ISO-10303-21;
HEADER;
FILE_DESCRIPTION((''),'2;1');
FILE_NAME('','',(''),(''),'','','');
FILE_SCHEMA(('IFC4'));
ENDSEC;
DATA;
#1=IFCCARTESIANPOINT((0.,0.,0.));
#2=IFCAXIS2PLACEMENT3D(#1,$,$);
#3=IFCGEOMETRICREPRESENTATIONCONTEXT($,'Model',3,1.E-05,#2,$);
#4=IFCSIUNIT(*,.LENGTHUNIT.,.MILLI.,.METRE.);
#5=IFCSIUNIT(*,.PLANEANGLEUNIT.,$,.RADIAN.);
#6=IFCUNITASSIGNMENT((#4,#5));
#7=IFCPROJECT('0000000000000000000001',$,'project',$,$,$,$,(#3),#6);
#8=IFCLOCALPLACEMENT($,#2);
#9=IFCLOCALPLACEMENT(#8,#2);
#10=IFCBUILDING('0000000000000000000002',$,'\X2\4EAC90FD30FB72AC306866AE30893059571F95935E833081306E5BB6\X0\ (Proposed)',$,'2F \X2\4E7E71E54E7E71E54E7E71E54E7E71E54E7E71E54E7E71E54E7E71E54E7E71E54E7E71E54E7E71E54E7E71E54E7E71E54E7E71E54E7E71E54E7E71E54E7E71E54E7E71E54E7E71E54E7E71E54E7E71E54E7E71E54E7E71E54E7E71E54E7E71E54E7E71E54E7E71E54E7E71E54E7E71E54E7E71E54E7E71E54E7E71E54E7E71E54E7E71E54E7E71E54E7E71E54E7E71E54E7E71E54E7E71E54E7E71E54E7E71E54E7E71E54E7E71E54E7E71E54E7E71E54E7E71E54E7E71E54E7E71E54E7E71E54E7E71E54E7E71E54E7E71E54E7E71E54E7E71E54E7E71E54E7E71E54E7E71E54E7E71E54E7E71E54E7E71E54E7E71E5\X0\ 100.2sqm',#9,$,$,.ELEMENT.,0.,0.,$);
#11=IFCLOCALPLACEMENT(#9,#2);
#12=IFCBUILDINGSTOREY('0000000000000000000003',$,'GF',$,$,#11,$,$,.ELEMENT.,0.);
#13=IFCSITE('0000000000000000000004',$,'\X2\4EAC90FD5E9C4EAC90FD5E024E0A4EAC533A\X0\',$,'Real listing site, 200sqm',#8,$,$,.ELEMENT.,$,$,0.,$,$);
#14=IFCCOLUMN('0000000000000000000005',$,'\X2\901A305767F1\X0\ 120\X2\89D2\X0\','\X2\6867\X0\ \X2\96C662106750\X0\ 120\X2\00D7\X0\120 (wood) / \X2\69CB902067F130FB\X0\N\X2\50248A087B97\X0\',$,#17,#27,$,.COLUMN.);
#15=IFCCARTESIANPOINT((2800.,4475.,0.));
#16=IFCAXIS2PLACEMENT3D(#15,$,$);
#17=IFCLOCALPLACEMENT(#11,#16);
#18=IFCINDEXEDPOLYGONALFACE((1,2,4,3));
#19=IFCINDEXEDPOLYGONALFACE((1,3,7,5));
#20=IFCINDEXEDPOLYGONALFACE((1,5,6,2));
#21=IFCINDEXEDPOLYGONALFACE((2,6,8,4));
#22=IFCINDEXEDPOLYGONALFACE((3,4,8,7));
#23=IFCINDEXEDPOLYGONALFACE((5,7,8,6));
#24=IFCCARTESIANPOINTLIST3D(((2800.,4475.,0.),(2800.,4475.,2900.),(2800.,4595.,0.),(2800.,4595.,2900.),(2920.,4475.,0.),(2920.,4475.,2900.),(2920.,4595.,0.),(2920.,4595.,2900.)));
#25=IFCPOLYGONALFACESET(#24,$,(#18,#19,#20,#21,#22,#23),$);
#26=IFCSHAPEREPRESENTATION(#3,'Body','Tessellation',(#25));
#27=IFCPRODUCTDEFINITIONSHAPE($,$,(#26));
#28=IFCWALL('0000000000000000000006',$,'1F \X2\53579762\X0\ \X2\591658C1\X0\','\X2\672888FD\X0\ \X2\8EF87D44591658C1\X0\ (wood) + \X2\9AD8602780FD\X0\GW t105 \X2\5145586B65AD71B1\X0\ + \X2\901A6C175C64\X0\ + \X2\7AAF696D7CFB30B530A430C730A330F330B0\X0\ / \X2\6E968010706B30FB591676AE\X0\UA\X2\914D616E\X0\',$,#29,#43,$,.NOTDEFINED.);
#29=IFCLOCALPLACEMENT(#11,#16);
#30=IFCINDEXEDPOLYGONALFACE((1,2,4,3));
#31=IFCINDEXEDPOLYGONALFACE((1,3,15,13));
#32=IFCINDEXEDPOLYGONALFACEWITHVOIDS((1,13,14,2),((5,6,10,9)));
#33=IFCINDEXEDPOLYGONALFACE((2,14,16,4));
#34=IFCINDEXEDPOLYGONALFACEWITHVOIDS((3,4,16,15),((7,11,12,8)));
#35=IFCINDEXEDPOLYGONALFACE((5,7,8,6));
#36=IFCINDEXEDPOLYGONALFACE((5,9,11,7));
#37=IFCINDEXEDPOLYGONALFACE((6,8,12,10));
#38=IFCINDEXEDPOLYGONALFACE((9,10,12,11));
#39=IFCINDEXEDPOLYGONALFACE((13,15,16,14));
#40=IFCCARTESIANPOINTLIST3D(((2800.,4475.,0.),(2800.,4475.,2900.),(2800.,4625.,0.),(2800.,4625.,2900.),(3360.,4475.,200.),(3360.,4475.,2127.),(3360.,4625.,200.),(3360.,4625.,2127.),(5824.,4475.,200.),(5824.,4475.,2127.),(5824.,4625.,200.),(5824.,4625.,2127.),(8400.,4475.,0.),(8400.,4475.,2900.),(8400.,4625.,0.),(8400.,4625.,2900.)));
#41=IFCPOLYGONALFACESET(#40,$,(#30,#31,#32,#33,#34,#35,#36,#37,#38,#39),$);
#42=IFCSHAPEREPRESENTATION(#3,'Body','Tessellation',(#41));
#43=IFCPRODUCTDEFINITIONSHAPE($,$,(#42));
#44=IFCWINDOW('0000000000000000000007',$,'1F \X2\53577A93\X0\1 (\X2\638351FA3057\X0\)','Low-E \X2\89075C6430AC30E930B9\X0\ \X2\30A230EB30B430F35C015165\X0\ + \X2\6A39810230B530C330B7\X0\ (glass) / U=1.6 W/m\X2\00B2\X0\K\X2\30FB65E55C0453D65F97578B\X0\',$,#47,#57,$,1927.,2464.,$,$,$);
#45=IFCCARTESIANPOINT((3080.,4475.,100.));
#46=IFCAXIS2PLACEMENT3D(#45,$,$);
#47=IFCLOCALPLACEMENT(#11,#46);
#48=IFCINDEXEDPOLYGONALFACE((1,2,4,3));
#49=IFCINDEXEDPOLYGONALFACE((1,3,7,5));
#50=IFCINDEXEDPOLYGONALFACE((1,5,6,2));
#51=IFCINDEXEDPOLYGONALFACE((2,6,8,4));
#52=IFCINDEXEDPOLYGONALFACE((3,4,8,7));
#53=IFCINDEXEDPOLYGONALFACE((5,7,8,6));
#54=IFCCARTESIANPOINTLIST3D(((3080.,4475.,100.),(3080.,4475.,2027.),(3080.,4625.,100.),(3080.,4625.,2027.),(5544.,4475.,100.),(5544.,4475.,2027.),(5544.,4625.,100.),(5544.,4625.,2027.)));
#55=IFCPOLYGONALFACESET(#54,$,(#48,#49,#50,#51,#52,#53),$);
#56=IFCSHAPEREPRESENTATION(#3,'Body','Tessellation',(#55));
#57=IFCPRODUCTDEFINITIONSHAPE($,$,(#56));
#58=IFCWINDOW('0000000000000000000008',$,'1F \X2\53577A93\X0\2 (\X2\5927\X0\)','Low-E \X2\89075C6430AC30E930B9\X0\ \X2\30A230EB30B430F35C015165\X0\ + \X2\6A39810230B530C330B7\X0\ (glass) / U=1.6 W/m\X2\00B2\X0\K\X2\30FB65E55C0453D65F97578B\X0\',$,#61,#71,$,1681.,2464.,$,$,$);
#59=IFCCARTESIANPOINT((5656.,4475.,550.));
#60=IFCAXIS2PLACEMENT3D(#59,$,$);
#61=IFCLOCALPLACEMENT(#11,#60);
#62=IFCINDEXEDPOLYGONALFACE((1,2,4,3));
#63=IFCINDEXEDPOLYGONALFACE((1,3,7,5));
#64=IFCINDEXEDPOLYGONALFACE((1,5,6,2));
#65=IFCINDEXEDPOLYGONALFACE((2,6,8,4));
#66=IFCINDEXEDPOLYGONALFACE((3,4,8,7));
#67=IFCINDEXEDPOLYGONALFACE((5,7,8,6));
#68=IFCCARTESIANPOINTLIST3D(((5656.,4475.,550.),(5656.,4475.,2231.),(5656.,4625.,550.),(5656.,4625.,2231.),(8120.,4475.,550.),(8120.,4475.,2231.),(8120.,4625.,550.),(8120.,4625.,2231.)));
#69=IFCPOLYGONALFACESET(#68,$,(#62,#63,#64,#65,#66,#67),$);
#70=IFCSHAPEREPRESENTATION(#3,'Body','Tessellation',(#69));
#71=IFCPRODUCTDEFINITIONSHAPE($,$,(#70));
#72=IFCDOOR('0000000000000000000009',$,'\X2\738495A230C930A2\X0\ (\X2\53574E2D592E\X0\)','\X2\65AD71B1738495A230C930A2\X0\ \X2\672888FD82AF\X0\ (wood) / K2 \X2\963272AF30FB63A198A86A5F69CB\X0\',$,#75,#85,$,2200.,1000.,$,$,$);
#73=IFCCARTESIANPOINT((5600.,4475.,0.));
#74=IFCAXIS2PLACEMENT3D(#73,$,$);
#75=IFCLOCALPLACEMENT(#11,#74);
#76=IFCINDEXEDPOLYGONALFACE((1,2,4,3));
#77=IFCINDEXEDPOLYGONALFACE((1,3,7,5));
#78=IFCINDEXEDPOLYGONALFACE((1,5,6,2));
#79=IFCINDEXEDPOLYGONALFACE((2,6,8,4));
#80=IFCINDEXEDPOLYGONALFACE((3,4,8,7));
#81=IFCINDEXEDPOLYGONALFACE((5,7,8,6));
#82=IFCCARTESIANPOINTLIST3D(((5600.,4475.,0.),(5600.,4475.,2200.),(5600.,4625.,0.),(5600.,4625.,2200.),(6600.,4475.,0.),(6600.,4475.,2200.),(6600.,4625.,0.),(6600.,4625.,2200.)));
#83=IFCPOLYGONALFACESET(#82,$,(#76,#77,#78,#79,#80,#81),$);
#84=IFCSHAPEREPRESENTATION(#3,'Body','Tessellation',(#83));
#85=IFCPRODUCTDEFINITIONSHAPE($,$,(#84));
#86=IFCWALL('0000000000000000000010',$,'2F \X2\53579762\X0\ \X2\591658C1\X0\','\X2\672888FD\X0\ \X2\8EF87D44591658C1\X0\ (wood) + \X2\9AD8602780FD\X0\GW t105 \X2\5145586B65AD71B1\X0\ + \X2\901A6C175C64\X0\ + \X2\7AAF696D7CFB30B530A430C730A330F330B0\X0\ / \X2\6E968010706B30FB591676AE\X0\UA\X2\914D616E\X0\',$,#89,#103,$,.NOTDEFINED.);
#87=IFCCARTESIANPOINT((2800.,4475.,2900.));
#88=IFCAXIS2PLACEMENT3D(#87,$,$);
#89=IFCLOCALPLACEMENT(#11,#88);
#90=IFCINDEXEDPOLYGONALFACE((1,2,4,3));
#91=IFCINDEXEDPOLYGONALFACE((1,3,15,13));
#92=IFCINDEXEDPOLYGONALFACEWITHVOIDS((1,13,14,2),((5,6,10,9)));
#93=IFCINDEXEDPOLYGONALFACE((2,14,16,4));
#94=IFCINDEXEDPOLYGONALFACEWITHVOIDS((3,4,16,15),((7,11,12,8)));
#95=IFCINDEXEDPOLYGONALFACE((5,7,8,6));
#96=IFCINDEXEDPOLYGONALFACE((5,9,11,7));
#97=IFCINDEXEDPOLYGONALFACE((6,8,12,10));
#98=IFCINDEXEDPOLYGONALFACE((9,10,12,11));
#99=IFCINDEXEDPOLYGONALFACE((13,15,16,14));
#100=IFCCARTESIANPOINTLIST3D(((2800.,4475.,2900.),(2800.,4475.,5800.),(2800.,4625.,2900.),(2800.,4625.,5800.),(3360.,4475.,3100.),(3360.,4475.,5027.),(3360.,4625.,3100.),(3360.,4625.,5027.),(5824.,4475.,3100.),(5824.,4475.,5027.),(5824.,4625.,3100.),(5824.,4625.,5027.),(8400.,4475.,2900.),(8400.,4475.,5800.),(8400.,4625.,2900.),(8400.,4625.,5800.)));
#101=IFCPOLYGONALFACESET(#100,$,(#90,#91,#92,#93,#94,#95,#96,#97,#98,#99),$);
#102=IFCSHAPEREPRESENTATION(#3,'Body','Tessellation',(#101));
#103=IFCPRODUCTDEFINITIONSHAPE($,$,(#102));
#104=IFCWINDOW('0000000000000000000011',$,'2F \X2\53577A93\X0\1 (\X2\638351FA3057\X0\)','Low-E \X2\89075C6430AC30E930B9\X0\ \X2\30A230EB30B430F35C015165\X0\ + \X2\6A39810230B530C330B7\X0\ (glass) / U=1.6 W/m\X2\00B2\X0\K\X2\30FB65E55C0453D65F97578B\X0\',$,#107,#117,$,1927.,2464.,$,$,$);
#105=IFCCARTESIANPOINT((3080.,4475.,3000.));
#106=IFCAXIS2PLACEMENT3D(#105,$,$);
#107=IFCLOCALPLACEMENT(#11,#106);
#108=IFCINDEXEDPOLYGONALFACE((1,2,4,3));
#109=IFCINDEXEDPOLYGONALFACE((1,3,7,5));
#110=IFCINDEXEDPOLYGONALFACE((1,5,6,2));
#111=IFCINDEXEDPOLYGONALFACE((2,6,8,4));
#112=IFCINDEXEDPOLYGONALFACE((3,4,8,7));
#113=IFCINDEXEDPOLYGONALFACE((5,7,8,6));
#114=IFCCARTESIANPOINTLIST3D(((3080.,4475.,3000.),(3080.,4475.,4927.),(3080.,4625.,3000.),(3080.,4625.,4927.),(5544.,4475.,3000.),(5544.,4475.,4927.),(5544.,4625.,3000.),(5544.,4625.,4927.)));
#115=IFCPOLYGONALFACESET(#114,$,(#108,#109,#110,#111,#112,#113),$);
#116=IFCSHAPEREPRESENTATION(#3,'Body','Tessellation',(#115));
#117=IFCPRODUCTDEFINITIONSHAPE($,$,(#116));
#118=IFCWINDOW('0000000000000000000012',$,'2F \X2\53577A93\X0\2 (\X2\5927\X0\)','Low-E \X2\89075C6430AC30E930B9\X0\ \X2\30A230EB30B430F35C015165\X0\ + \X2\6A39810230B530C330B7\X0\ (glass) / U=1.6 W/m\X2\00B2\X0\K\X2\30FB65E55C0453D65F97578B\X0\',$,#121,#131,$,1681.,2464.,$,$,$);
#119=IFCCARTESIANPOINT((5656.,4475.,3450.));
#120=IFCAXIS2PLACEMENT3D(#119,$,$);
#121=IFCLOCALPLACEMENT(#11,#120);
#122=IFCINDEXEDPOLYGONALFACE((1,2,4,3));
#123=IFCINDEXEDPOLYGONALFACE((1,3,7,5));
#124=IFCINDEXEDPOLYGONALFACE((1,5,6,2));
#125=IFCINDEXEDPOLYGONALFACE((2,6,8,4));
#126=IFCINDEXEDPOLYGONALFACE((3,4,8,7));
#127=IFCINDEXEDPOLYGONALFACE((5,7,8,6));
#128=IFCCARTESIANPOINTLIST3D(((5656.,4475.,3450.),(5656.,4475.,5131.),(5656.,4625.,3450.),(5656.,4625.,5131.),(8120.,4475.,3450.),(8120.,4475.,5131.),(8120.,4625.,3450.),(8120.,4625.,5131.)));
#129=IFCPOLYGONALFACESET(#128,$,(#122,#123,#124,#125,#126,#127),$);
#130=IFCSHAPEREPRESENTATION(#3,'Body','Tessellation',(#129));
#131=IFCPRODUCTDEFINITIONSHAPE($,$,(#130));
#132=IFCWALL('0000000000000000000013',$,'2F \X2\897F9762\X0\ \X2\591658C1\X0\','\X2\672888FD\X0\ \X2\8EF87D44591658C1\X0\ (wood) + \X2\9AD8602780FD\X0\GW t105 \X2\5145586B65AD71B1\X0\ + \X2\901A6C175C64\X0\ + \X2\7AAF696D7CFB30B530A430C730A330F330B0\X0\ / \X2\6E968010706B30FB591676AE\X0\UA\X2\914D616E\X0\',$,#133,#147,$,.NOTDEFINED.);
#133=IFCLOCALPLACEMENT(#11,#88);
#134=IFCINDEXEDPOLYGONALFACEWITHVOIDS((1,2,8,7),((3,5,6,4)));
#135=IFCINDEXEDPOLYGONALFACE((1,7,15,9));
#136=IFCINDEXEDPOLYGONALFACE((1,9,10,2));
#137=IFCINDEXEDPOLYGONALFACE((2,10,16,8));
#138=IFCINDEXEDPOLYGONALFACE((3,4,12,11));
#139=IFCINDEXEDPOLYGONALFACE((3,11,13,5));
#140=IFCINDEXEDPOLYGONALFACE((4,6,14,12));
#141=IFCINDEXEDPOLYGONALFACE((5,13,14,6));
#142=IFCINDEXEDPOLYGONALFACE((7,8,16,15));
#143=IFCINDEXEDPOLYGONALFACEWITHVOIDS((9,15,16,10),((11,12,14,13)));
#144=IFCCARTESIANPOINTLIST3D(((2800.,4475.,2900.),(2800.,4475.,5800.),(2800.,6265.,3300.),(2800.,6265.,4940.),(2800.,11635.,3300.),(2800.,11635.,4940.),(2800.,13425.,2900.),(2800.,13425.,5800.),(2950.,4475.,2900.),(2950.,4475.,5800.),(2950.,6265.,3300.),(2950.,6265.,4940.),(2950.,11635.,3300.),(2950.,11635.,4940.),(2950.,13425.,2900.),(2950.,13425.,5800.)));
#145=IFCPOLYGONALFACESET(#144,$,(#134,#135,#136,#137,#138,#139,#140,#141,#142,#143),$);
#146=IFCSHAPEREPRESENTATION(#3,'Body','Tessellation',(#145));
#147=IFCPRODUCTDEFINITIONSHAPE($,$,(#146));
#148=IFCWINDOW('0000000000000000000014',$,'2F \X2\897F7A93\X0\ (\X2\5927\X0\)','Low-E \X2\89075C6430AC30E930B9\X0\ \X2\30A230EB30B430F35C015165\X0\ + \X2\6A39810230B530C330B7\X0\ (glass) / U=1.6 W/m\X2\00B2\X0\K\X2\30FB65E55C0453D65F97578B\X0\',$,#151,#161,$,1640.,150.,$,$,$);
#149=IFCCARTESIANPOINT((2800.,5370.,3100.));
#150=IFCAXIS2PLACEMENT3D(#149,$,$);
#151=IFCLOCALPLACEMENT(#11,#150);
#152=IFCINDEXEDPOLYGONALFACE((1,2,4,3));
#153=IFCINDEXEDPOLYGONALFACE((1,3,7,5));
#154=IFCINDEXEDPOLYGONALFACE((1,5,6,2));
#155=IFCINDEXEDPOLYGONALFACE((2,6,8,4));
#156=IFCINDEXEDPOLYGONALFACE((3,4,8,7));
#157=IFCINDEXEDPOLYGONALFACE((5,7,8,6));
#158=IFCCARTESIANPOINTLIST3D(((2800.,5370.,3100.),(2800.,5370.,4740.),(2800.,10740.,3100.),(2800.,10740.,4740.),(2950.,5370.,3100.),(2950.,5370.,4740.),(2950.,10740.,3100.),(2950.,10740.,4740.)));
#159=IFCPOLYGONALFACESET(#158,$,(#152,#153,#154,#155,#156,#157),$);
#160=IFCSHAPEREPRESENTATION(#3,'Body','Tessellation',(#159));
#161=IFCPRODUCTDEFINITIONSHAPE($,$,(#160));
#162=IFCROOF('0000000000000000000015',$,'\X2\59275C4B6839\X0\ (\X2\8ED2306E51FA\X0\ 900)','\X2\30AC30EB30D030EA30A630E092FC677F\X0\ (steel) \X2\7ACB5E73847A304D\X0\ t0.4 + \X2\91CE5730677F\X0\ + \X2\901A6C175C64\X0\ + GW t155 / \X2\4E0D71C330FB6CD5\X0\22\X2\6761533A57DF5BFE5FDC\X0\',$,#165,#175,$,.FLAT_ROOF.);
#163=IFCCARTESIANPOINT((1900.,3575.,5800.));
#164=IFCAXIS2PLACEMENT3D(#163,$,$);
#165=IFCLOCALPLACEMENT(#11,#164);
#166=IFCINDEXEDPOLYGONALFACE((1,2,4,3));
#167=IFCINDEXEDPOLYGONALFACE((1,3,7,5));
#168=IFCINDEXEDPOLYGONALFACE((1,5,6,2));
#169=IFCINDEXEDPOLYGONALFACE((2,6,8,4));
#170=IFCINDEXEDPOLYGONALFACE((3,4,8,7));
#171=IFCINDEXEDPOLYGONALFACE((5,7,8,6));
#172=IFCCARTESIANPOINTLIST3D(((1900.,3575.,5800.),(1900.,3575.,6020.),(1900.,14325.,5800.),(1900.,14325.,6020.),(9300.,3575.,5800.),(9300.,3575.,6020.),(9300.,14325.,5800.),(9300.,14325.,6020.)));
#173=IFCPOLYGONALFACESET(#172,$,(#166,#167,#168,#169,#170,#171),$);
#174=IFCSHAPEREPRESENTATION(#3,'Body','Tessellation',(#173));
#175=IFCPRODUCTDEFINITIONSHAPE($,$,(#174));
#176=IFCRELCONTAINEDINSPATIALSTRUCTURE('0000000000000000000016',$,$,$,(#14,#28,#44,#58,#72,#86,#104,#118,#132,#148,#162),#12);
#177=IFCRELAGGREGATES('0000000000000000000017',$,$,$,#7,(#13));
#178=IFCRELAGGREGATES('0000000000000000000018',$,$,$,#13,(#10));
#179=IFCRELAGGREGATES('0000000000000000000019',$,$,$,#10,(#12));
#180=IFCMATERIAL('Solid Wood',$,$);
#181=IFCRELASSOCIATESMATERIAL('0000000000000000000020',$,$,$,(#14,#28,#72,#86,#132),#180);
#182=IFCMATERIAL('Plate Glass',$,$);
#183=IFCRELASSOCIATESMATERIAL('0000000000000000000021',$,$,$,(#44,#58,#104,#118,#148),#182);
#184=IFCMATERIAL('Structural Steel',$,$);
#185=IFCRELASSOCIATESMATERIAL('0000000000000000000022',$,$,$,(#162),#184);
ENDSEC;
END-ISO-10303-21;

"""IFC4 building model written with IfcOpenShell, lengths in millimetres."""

from ifc_helpers import new_model, si_unit, frame, frame_2d, origin, place, context, project, spatial, rectangle, extrude, material, element, fill, save


model = new_model("IFC4")

# Units and contexts
model_context = context("Model", 3, precision=1e-05, world=origin())
ifc_project = project(units=[si_unit("LENGTHUNIT", "METRE", prefix="MILLI"), si_unit("PLANEANGLEUNIT", "RADIAN")], contexts=[model_context])

# Site, building, storey
site_placement = place(None, origin())
site = spatial("IfcSite", under=ifc_project, at=site_placement, Name="京都府京都市上京区", ObjectType="Real listing site, 200sqm", CompositionType="ELEMENT", RefElevation=0.0)
building_placement = place(site_placement, origin())
building = spatial("IfcBuilding", under=site, at=building_placement, Name="京都・犬と暮らす土間広めの家 (Proposed)", ObjectType="2F 乾燥乾燥乾燥乾燥乾燥乾燥乾燥乾燥乾燥乾燥乾燥乾燥乾燥乾燥乾燥乾燥乾燥乾燥乾燥乾燥乾燥乾燥乾燥乾燥乾燥乾燥乾燥乾燥乾燥乾燥乾燥乾燥乾燥乾燥乾燥乾燥乾燥乾燥乾燥乾燥乾燥乾燥乾燥乾燥乾燥乾燥乾燥乾燥乾燥乾燥乾燥乾燥乾燥乾燥乾燥乾燥乾燥乾燥乾燥乾燥 100.2sqm", CompositionType="ELEMENT", ElevationOfRefHeight=0.0, ElevationOfTerrain=0.0)
storey_placement = place(building_placement, origin())
storey = spatial("IfcBuildingStorey", under=building, at=storey_placement, Name="GF", CompositionType="ELEMENT", Elevation=0.0)

# Column
ifc_material_1 = material(Name="Solid Wood")
column_placement = place(storey_placement, frame((2800.0, 4475.0, 0.0)))
element("IfcColumn", 1, at=column_placement, inside=storey, material=ifc_material_1, Name="通し柱 120角", Description="桧 集成材 120×120 (wood) / 構造柱・N値計算", PredefinedType="COLUMN", context=model_context, shape_type="SweptSolid", body=[
    extrude(rectangle(XDim=120.0, YDim=120.0, at=frame_2d((60.0, 60.0))), frame((2800.0, 4475.0, 0.0)), (0.0, 0.0, 1.0), 2900.0),
])

# Wall, openings, windows, door
wall_1_placement = place(storey_placement, frame((2800.0, 4475.0, 0.0)))
wall_1 = element("IfcWall", 2, at=wall_1_placement, inside=storey, material=ifc_material_1, Name="1F 南面 外壁", Description="木製 軸組外壁 (wood) + 高性能GW t105 充填断熱 + 通気層 + 窯業系サイディング / 準耐火・外皮UA配慮", PredefinedType="NOTDEFINED", context=model_context, shape_type="SweptSolid", body=[
    extrude(rectangle(XDim=5600.0, YDim=150.0, at=frame_2d((2800.0, 75.0))), frame((2800.0, 4475.0, 0.0)), (0.0, 0.0, 1.0), 2900.0),
])
opening_1_placement = place(storey_placement, frame((3080.0, 4475.0, 100.0)))
opening_1 = element("IfcOpeningElement", 3, at=opening_1_placement, cuts=wall_1, PredefinedType="NOTDEFINED", context=model_context, shape_type="SweptSolid", body=[
    extrude(rectangle(XDim=2464.0, YDim=150.0, at=frame_2d((1232.0, 75.0))), frame((3080.0, 4475.0, 100.0)), (0.0, 0.0, 1.0), 1927.0),
])
opening_2_placement = place(storey_placement, frame((5656.0, 4475.0, 550.0)))
opening_2 = element("IfcOpeningElement", 4, at=opening_2_placement, cuts=wall_1, PredefinedType="NOTDEFINED", context=model_context, shape_type="SweptSolid", body=[
    extrude(rectangle(XDim=2464.0, YDim=150.0, at=frame_2d((1232.0, 75.0))), frame((5656.0, 4475.0, 550.0)), (0.0, 0.0, 1.0), 1681.0),
])
opening_3_placement = place(storey_placement, frame((5600.0, 4475.0, 0.0)))
opening_3 = element("IfcOpeningElement", 5, at=opening_3_placement, cuts=wall_1, PredefinedType="NOTDEFINED", context=model_context, shape_type="SweptSolid", body=[
    extrude(rectangle(XDim=1000.0, YDim=150.0, at=frame_2d((500.0, 75.0))), frame((5600.0, 4475.0, 0.0)), (0.0, 0.0, 1.0), 2200.0),
])
ifc_material_2 = material(Name="Plate Glass")
window_1_placement = place(storey_placement, frame((3080.0, 4475.0, 100.0)))
window_1 = element("IfcWindow", 6, at=window_1_placement, inside=storey, material=ifc_material_2, Name="1F 南窓1 (掃出し)", Description="Low-E 複層ガラス アルゴン封入 + 樹脂サッシ (glass) / U=1.6 W/m²K・日射取得型", OverallHeight=1927.0, OverallWidth=2464.0, context=model_context, shape_type="SweptSolid", body=[
    extrude(rectangle(XDim=2464.0, YDim=150.0, at=frame_2d((1232.0, 75.0))), frame((3080.0, 4475.0, 100.0)), (0.0, 0.0, 1.0), 1927.0),
])
fill(opening_1, window_1)
window_2_placement = place(storey_placement, frame((5656.0, 4475.0, 550.0)))
window_2 = element("IfcWindow", 7, at=window_2_placement, inside=storey, material=ifc_material_2, Name="1F 南窓2 (大)", Description="Low-E 複層ガラス アルゴン封入 + 樹脂サッシ (glass) / U=1.6 W/m²K・日射取得型", OverallHeight=1681.0, OverallWidth=2464.0, context=model_context, shape_type="SweptSolid", body=[
    extrude(rectangle(XDim=2464.0, YDim=150.0, at=frame_2d((1232.0, 75.0))), frame((5656.0, 4475.0, 550.0)), (0.0, 0.0, 1.0), 1681.0),
])
fill(opening_2, window_2)
door_placement = place(storey_placement, frame((5600.0, 4475.0, 0.0)))
door = element("IfcDoor", 8, at=door_placement, inside=storey, material=ifc_material_1, Name="玄関ドア (南中央)", Description="断熱玄関ドア 木製芯 (wood) / K2 防犯・採風機構", OverallHeight=2200.0, OverallWidth=1000.0, context=model_context, shape_type="SweptSolid", body=[
    extrude(rectangle(XDim=1000.0, YDim=150.0, at=frame_2d((500.0, 75.0))), frame((5600.0, 4475.0, 0.0)), (0.0, 0.0, 1.0), 2200.0),
])
fill(opening_3, door)

# Wall, openings, windows
wall_2_placement = place(storey_placement, frame((2800.0, 4475.0, 2900.0)))
wall_2 = element("IfcWall", 9, at=wall_2_placement, inside=storey, material=ifc_material_1, Name="2F 南面 外壁", Description="木製 軸組外壁 (wood) + 高性能GW t105 充填断熱 + 通気層 + 窯業系サイディング / 準耐火・外皮UA配慮", PredefinedType="NOTDEFINED", context=model_context, shape_type="SweptSolid", body=[
    extrude(rectangle(XDim=5600.0, YDim=150.0, at=frame_2d((2800.0, 75.0))), frame((2800.0, 4475.0, 2900.0)), (0.0, 0.0, 1.0), 2900.0),
])
opening_4_placement = place(storey_placement, frame((3080.0, 4475.0, 3000.0)))
opening_4 = element("IfcOpeningElement", 10, at=opening_4_placement, cuts=wall_2, PredefinedType="NOTDEFINED", context=model_context, shape_type="SweptSolid", body=[
    extrude(rectangle(XDim=2464.0, YDim=150.0, at=frame_2d((1232.0, 75.0))), frame((3080.0, 4475.0, 3000.0)), (0.0, 0.0, 1.0), 1927.0),
])
opening_5_placement = place(storey_placement, frame((5656.0, 4475.0, 3450.0)))
opening_5 = element("IfcOpeningElement", 11, at=opening_5_placement, cuts=wall_2, PredefinedType="NOTDEFINED", context=model_context, shape_type="SweptSolid", body=[
    extrude(rectangle(XDim=2464.0, YDim=150.0, at=frame_2d((1232.0, 75.0))), frame((5656.0, 4475.0, 3450.0)), (0.0, 0.0, 1.0), 1681.0),
])
window_3_placement = place(storey_placement, frame((3080.0, 4475.0, 3000.0)))
window_3 = element("IfcWindow", 12, at=window_3_placement, inside=storey, material=ifc_material_2, Name="2F 南窓1 (掃出し)", Description="Low-E 複層ガラス アルゴン封入 + 樹脂サッシ (glass) / U=1.6 W/m²K・日射取得型", OverallHeight=1927.0, OverallWidth=2464.0, context=model_context, shape_type="SweptSolid", body=[
    extrude(rectangle(XDim=2464.0, YDim=150.0, at=frame_2d((1232.0, 75.0))), frame((3080.0, 4475.0, 3000.0)), (0.0, 0.0, 1.0), 1927.0),
])
fill(opening_4, window_3)
window_4_placement = place(storey_placement, frame((5656.0, 4475.0, 3450.0)))
window_4 = element("IfcWindow", 13, at=window_4_placement, inside=storey, material=ifc_material_2, Name="2F 南窓2 (大)", Description="Low-E 複層ガラス アルゴン封入 + 樹脂サッシ (glass) / U=1.6 W/m²K・日射取得型", OverallHeight=1681.0, OverallWidth=2464.0, context=model_context, shape_type="SweptSolid", body=[
    extrude(rectangle(XDim=2464.0, YDim=150.0, at=frame_2d((1232.0, 75.0))), frame((5656.0, 4475.0, 3450.0)), (0.0, 0.0, 1.0), 1681.0),
])
fill(opening_5, window_4)

# Wall, opening, window
wall_3_placement = place(storey_placement, frame((2800.0, 4475.0, 2900.0)))
wall_3 = element("IfcWall", 14, at=wall_3_placement, inside=storey, material=ifc_material_1, Name="2F 西面 外壁", Description="木製 軸組外壁 (wood) + 高性能GW t105 充填断熱 + 通気層 + 窯業系サイディング / 準耐火・外皮UA配慮", PredefinedType="NOTDEFINED", context=model_context, shape_type="SweptSolid", body=[
    extrude(rectangle(XDim=150.0, YDim=8950.0, at=frame_2d((75.0, 4475.0))), frame((2800.0, 4475.0, 2900.0)), (0.0, 0.0, 1.0), 2900.0),
])
opening_6_placement = place(storey_placement, frame((2800.0, 5370.0, 3100.0)))
opening_6 = element("IfcOpeningElement", 15, at=opening_6_placement, cuts=wall_3, PredefinedType="NOTDEFINED", context=model_context, shape_type="SweptSolid", body=[
    extrude(rectangle(XDim=150.0, YDim=5370.0, at=frame_2d((75.0, 2685.0))), frame((2800.0, 5370.0, 3100.0)), (0.0, 0.0, 1.0), 1640.0),
])
window_5_placement = place(storey_placement, frame((2800.0, 5370.0, 3100.0)))
window_5 = element("IfcWindow", 16, at=window_5_placement, inside=storey, material=ifc_material_2, Name="2F 西窓 (大)", Description="Low-E 複層ガラス アルゴン封入 + 樹脂サッシ (glass) / U=1.6 W/m²K・日射取得型", OverallHeight=1640.0, OverallWidth=150.0, context=model_context, shape_type="SweptSolid", body=[
    extrude(rectangle(XDim=150.0, YDim=5370.0, at=frame_2d((75.0, 2685.0))), frame((2800.0, 5370.0, 3100.0)), (0.0, 0.0, 1.0), 1640.0),
])
fill(opening_6, window_5)

# Roof
ifc_material_3 = material(Name="Structural Steel")
roof_placement = place(storey_placement, frame((1900.0, 3575.0, 5800.0)))
element("IfcRoof", 17, at=roof_placement, inside=storey, material=ifc_material_3, Name="大屋根 (軒の出 900)", Description="ガルバリウム鋼板 (steel) 立平葺き t0.4 + 野地板 + 通気層 + GW t155 / 不燃・法22条区域対応", PredefinedType="FLAT_ROOF", context=model_context, shape_type="SweptSolid", body=[
    extrude(rectangle(XDim=7400.0, YDim=10750.0, at=frame_2d((3700.0, 5375.0))), frame((1900.0, 3575.0, 5800.0)), (0.0, 0.0, 1.0), 220.0),
])

save(model, "model.ifc")
